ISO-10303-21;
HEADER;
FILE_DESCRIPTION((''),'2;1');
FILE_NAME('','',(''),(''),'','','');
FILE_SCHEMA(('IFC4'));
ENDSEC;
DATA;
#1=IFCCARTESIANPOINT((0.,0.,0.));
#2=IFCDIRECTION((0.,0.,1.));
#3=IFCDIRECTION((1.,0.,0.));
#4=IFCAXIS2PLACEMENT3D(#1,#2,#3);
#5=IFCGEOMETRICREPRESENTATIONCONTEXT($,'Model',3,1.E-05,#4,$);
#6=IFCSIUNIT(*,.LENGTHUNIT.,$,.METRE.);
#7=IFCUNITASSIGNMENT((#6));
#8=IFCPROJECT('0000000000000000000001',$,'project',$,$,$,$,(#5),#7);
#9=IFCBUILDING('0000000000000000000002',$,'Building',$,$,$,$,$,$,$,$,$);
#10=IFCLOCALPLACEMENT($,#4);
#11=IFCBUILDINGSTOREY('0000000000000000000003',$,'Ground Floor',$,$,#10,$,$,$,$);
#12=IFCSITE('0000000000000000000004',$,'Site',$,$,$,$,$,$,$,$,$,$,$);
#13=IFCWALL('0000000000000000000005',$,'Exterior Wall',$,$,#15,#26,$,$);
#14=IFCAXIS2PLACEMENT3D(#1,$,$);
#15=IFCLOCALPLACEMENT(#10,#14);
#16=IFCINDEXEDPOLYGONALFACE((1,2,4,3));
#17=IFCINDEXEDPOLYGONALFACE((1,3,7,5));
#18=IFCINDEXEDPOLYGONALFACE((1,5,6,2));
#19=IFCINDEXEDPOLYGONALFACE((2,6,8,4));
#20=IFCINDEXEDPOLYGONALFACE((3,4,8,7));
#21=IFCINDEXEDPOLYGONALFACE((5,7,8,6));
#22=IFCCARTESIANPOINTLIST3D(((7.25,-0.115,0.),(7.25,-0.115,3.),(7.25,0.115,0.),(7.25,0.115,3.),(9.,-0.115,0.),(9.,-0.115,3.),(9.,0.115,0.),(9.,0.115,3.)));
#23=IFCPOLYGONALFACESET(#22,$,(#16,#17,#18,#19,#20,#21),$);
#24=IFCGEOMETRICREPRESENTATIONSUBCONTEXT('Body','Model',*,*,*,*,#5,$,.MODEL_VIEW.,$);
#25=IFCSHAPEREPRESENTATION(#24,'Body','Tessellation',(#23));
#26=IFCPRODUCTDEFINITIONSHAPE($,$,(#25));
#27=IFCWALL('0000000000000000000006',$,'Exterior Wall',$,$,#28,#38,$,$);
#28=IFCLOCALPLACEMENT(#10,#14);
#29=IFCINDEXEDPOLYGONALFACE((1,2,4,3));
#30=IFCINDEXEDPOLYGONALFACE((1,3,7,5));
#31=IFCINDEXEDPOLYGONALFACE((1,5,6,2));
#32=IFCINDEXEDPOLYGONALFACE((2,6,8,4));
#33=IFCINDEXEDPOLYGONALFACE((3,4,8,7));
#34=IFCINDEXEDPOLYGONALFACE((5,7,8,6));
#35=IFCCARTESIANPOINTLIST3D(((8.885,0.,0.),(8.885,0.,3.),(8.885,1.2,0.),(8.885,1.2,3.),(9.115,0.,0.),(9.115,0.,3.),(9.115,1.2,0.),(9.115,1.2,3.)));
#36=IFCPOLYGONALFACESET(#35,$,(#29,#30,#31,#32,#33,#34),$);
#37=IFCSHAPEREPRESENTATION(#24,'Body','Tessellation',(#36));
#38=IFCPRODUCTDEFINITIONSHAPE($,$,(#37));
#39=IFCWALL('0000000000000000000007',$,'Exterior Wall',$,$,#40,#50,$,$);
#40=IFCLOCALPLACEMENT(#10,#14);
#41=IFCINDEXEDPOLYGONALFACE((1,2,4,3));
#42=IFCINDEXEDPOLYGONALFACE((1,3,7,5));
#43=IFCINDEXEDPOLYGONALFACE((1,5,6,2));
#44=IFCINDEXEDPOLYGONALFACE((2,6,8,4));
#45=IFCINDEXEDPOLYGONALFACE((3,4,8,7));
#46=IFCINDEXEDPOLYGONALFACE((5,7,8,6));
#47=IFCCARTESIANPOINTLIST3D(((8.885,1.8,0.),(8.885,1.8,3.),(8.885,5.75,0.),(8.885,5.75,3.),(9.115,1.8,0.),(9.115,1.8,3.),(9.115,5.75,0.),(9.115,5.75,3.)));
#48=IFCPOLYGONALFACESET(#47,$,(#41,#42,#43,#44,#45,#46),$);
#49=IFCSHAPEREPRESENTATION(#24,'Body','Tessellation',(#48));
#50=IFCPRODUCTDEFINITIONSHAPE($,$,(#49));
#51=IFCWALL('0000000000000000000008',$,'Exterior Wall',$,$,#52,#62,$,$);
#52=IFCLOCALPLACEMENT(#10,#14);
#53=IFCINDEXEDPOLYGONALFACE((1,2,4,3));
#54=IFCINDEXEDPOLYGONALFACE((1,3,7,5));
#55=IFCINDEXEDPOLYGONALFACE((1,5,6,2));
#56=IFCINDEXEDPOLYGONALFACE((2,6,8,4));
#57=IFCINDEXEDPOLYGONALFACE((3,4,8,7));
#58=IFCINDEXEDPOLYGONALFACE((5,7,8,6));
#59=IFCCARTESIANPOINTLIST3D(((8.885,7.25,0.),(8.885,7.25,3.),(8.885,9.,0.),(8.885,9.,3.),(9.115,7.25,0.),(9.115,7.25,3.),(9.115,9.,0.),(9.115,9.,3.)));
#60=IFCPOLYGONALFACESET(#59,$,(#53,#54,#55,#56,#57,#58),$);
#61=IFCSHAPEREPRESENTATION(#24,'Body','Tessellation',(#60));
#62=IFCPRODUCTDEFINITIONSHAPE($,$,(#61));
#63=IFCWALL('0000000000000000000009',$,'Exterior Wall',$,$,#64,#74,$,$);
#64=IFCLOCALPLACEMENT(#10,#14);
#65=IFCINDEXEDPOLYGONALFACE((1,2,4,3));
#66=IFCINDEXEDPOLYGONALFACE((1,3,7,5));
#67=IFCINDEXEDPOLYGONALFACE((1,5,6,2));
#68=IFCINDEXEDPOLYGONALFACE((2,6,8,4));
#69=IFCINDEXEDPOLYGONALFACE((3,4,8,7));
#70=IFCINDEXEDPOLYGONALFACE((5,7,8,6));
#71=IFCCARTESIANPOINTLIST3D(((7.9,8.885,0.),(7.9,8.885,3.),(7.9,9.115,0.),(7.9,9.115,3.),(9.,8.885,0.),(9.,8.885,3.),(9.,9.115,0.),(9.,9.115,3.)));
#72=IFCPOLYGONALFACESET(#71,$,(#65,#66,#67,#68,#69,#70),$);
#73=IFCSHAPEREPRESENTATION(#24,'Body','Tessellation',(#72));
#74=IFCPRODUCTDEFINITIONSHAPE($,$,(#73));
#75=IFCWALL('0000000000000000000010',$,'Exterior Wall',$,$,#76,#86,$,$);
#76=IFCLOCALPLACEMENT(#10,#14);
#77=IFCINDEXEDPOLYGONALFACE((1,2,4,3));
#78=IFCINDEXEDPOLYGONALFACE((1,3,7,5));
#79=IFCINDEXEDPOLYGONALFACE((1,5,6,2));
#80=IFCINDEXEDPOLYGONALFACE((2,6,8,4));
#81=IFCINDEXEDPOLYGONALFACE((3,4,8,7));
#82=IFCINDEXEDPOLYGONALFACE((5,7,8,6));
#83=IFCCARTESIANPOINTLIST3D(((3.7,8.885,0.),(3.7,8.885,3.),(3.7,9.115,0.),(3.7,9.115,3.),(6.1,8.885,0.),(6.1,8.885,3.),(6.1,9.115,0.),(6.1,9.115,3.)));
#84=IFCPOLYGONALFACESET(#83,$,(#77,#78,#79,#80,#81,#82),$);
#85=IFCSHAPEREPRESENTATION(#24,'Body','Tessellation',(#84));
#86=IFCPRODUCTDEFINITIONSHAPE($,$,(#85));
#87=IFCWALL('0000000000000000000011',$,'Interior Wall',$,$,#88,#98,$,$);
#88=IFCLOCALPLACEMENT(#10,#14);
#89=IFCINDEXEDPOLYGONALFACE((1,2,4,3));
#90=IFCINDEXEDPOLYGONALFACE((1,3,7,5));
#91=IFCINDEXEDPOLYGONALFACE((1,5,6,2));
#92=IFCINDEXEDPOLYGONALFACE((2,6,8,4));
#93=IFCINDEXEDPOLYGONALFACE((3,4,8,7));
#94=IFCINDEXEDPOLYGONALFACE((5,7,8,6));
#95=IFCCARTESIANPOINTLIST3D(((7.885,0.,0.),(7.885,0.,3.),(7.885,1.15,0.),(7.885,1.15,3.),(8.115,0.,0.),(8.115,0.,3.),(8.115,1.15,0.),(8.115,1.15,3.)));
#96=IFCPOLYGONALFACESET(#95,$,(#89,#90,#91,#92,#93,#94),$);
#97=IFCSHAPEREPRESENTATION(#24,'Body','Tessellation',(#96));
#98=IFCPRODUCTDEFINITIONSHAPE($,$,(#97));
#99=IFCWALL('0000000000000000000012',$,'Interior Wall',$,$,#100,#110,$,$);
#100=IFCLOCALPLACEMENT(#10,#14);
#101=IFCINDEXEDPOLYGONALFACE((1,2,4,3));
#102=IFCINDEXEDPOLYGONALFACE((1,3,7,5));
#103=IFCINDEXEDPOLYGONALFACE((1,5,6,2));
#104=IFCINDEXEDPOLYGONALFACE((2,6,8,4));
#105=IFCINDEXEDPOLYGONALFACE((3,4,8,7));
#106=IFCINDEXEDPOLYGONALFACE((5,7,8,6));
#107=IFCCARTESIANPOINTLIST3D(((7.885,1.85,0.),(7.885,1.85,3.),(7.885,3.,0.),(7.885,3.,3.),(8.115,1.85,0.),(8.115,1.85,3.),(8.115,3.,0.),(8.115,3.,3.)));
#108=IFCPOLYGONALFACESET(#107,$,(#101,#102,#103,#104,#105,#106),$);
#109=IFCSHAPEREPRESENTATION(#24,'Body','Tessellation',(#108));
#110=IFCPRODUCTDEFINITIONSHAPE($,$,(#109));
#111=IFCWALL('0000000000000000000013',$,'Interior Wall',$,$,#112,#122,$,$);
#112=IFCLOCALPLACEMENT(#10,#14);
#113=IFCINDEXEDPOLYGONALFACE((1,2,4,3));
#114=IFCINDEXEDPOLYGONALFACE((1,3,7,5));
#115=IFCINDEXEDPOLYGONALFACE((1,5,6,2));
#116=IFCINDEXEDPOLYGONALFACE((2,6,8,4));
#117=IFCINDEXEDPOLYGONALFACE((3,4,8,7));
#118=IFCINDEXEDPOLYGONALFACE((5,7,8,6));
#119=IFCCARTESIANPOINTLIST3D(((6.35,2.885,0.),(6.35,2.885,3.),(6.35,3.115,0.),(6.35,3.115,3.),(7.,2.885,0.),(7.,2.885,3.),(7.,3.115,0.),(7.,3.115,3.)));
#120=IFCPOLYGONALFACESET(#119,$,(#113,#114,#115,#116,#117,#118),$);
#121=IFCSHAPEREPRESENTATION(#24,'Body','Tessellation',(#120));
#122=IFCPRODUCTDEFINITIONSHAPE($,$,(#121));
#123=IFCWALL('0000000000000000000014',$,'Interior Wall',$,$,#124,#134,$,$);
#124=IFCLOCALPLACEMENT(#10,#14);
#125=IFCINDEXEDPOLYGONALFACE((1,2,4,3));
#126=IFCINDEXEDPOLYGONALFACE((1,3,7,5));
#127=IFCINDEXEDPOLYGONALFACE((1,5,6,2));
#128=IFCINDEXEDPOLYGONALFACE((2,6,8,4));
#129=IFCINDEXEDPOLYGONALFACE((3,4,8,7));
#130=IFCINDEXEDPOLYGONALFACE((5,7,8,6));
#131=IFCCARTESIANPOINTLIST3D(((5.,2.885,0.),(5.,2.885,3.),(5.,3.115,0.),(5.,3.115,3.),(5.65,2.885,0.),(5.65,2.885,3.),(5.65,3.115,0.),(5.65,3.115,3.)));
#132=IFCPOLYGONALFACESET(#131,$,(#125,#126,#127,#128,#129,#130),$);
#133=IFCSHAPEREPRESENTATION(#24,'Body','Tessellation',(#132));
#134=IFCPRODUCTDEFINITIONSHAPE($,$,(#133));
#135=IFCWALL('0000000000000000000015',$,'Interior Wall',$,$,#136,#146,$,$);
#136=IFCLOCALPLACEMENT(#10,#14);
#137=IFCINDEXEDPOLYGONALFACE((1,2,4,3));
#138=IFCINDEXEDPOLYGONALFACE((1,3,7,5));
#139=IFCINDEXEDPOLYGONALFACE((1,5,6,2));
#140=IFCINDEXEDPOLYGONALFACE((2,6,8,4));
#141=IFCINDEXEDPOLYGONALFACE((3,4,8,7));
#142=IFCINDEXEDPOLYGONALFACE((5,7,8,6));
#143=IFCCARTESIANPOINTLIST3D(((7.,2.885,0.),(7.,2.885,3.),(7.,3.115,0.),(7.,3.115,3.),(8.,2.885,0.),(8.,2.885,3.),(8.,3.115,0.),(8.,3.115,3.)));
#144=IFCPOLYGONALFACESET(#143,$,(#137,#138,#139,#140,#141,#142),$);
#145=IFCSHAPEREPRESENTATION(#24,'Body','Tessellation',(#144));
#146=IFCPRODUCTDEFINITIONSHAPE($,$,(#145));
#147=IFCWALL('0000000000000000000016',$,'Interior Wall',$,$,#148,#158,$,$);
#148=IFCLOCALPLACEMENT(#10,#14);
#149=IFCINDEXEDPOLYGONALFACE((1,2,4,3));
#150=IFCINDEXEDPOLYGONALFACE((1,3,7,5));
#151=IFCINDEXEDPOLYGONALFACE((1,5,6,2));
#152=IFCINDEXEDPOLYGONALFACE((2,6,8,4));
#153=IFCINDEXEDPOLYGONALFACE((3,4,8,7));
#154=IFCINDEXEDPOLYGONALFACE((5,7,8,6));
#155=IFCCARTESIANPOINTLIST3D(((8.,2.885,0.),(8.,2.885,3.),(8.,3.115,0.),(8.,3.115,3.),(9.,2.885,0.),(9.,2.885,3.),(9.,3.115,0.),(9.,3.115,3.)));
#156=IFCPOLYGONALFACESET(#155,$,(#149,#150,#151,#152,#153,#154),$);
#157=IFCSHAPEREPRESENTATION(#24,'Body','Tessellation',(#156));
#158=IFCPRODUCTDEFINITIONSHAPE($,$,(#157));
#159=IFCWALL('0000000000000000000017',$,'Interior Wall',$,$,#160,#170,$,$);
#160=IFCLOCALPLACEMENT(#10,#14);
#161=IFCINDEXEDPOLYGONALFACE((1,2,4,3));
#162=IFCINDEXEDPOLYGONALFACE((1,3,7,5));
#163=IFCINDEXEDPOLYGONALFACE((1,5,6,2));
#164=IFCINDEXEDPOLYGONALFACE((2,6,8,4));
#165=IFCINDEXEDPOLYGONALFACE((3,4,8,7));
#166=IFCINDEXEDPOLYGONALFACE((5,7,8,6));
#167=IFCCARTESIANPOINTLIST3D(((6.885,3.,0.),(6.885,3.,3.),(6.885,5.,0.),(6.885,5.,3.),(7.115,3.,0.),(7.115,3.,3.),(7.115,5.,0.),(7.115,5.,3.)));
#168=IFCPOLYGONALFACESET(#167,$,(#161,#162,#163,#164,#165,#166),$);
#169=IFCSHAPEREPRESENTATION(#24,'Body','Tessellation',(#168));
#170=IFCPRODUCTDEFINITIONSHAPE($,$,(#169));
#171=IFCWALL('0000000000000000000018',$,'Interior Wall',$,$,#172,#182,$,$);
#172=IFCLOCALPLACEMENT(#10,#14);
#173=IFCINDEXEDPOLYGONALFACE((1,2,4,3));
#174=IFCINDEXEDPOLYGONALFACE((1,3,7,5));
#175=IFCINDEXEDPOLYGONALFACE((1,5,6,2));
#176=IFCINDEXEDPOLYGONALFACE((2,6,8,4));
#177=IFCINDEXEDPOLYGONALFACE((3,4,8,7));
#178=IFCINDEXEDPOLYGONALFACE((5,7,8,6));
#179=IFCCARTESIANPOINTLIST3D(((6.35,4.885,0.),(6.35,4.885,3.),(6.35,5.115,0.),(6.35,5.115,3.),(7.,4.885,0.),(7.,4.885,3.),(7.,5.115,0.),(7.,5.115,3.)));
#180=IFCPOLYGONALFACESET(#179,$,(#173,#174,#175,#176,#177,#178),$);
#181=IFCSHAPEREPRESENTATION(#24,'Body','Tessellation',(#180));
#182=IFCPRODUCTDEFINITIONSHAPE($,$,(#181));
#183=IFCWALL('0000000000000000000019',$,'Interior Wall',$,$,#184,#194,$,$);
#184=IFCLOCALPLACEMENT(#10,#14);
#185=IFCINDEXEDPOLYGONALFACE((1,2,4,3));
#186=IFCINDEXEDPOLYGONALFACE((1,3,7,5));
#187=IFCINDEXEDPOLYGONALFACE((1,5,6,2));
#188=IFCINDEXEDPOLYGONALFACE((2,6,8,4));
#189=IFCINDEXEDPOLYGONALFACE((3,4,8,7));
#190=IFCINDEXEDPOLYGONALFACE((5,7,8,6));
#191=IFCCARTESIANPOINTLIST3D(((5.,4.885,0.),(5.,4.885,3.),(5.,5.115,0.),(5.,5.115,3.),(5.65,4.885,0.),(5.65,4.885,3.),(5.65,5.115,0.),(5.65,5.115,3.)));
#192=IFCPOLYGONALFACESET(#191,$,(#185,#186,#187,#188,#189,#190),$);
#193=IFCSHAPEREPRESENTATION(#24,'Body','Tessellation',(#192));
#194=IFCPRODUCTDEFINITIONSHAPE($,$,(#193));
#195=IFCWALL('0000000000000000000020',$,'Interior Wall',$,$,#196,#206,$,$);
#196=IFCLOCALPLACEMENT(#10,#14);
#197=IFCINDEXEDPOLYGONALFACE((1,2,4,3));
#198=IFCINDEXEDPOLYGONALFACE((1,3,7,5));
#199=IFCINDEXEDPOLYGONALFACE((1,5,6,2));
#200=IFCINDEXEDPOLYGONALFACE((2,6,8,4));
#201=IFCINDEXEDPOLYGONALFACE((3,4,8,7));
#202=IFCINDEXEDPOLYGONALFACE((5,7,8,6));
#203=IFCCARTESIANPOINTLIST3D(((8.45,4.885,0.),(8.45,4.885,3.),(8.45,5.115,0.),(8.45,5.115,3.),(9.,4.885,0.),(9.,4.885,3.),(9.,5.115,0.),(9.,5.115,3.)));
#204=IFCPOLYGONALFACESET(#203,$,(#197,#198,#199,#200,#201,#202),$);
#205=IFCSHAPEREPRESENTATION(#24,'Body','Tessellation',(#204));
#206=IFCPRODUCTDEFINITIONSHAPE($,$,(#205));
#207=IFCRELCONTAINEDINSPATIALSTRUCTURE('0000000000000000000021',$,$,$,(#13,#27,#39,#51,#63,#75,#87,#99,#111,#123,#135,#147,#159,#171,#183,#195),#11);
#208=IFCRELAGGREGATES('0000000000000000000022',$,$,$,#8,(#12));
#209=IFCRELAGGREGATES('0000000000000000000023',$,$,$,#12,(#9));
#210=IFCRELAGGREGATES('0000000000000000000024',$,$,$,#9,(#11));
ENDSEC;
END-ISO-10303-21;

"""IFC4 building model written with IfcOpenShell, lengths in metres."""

from ifc_helpers import new_model, si_unit, frame, origin_with_axes, place, context, subcontext, project, spatial, indexed_curve, outline, extrude, element, save


model = new_model("IFC4")

# Units and contexts
model_context = context("Model", 3, precision=1e-05, world=origin_with_axes())
body_context = subcontext(model_context, "Body", "Model", "MODEL_VIEW")
ifc_project = project(units=[si_unit("LENGTHUNIT", "METRE")], contexts=[model_context])

# Site, building, storey
site = spatial("IfcSite", under=ifc_project, Name="Site")
building = spatial("IfcBuilding", under=site, Name="Building")
storey_placement = place(None, origin_with_axes())
storey = spatial("IfcBuildingStorey", under=building, at=storey_placement, Name="Ground Floor")

# Walls
wall_1_placement = place(storey_placement, frame((7.25, 0.0, 0.0), z_axis=(0.0, 0.0, 1.0), x_axis=(1.0, 0.0, 0.0)))
element("IfcWall", 1, at=wall_1_placement, inside=storey, Name="Exterior Wall", context=body_context, shape_type="SweptSolid", body=[
    extrude(outline(indexed_curve([(0.0, 0.0), (0.0, 0.23), (1.75, 0.23), (1.75, 0.0), (0.0, 0.0)], self_intersect=False)), frame((0.0, -0.115, 0.0), z_axis=(0.0, 0.0, 1.0), x_axis=(1.0, 0.0, 0.0)), (0.0, 0.0, 1.0), 3.0),
])
wall_2_placement = place(storey_placement, frame((9.0, 0.0, 0.0), z_axis=(0.0, 0.0, 1.0), x_axis=(0.0, 1.0, 0.0)))
element("IfcWall", 2, at=wall_2_placement, inside=storey, Name="Exterior Wall", context=body_context, shape_type="SweptSolid", body=[
    extrude(outline(indexed_curve([(0.0, 0.0), (0.0, 0.23), (1.2, 0.23), (1.2, 0.0), (0.0, 0.0)], self_intersect=False)), frame((0.0, -0.115, 0.0), z_axis=(0.0, 0.0, 1.0), x_axis=(1.0, 0.0, 0.0)), (0.0, 0.0, 1.0), 3.0),
])
wall_3_placement = place(storey_placement, frame((9.0, 1.8, 0.0), z_axis=(0.0, 0.0, 1.0), x_axis=(0.0, 1.0, 0.0)))
element("IfcWall", 3, at=wall_3_placement, inside=storey, Name="Exterior Wall", context=body_context, shape_type="SweptSolid", body=[
    extrude(outline(indexed_curve([(0.0, 0.0), (0.0, 0.23), (3.95, 0.23), (3.95, 0.0), (0.0, 0.0)], self_intersect=False)), frame((0.0, -0.115, 0.0), z_axis=(0.0, 0.0, 1.0), x_axis=(1.0, 0.0, 0.0)), (0.0, 0.0, 1.0), 3.0),
])
wall_4_placement = place(storey_placement, frame((9.0, 7.25, 0.0), z_axis=(0.0, 0.0, 1.0), x_axis=(0.0, 1.0, 0.0)))
element("IfcWall", 4, at=wall_4_placement, inside=storey, Name="Exterior Wall", context=body_context, shape_type="SweptSolid", body=[
    extrude(outline(indexed_curve([(0.0, 0.0), (0.0, 0.23), (1.75, 0.23), (1.75, 0.0), (0.0, 0.0)], self_intersect=False)), frame((0.0, -0.115, 0.0), z_axis=(0.0, 0.0, 1.0), x_axis=(1.0, 0.0, 0.0)), (0.0, 0.0, 1.0), 3.0),
])
wall_5_placement = place(storey_placement, frame((9.0, 9.0, 0.0), z_axis=(0.0, 0.0, 1.0), x_axis=(-1.0, 0.0, 0.0)))
element("IfcWall", 5, at=wall_5_placement, inside=storey, Name="Exterior Wall", context=body_context, shape_type="SweptSolid", body=[
    extrude(outline(indexed_curve([(0.0, 0.0), (0.0, 0.23), (1.1, 0.23), (1.1, 0.0), (0.0, 0.0)], self_intersect=False)), frame((0.0, -0.115, 0.0), z_axis=(0.0, 0.0, 1.0), x_axis=(1.0, 0.0, 0.0)), (0.0, 0.0, 1.0), 3.0),
])
wall_6_placement = place(storey_placement, frame((6.1, 9.0, 0.0), z_axis=(0.0, 0.0, 1.0), x_axis=(-1.0, 0.0, 0.0)))
element("IfcWall", 6, at=wall_6_placement, inside=storey, Name="Exterior Wall", context=body_context, shape_type="SweptSolid", body=[
    extrude(outline(indexed_curve([(0.0, 0.0), (0.0, 0.23), (2.4, 0.23), (2.4, 0.0), (0.0, 0.0)], self_intersect=False)), frame((0.0, -0.115, 0.0), z_axis=(0.0, 0.0, 1.0), x_axis=(1.0, 0.0, 0.0)), (0.0, 0.0, 1.0), 3.0),
])
for number, where, z_axis, x_axis, name in (
    (7, (8.0, 0.0, 0.0), (0.0, 0.0, 1.0), (0.0, 1.0, 0.0), "Interior Wall"),
    (8, (8.0, 1.85, 0.0), (0.0, 0.0, 1.0), (0.0, 1.0, 0.0), "Interior Wall"),
):
    element("IfcWall", number, at=place(storey_placement, frame(where, z_axis=z_axis, x_axis=x_axis)), inside=storey, Name=name, context=body_context, shape_type="SweptSolid", body=[
        extrude(outline(indexed_curve([(0.0, 0.0), (0.0, 0.23), (1.15, 0.23), (1.15, 0.0), (0.0, 0.0)], self_intersect=False)), frame((0.0, -0.115, 0.0), z_axis=(0.0, 0.0, 1.0), x_axis=(1.0, 0.0, 0.0)), (0.0, 0.0, 1.0), 3.0),
    ])
for number, where, z_axis, x_axis, name in (
    (9, (7.0, 3.0, 0.0), (0.0, 0.0, 1.0), (-1.0, 0.0, 0.0), "Interior Wall"),
    (10, (5.65, 3.0, 0.0), (0.0, 0.0, 1.0), (-1.0, 0.0, 0.0), "Interior Wall"),
):
    element("IfcWall", number, at=place(storey_placement, frame(where, z_axis=z_axis, x_axis=x_axis)), inside=storey, Name=name, context=body_context, shape_type="SweptSolid", body=[
        extrude(outline(indexed_curve([(0.0, 0.0), (0.0, 0.23), (0.65, 0.23), (0.65, 0.0), (0.0, 0.0)], self_intersect=False)), frame((0.0, -0.115, 0.0), z_axis=(0.0, 0.0, 1.0), x_axis=(1.0, 0.0, 0.0)), (0.0, 0.0, 1.0), 3.0),
    ])
for number, where, z_axis, x_axis, name in (
    (11, (8.0, 3.0, 0.0), (0.0, 0.0, 1.0), (-1.0, 0.0, 0.0), "Interior Wall"),
    (12, (9.0, 3.0, 0.0), (0.0, 0.0, 1.0), (-1.0, 0.0, 0.0), "Interior Wall"),
):
    element("IfcWall", number, at=place(storey_placement, frame(where, z_axis=z_axis, x_axis=x_axis)), inside=storey, Name=name, context=body_context, shape_type="SweptSolid", body=[
        extrude(outline(indexed_curve([(0.0, 0.0), (0.0, 0.23), (1.0, 0.23), (1.0, 0.0), (0.0, 0.0)], self_intersect=False)), frame((0.0, -0.115, 0.0), z_axis=(0.0, 0.0, 1.0), x_axis=(1.0, 0.0, 0.0)), (0.0, 0.0, 1.0), 3.0),
    ])
wall_7_placement = place(storey_placement, frame((7.0, 3.0, 0.0), z_axis=(0.0, 0.0, 1.0), x_axis=(0.0, 1.0, 0.0)))
element("IfcWall", 13, at=wall_7_placement, inside=storey, Name="Interior Wall", context=body_context, shape_type="SweptSolid", body=[
    extrude(outline(indexed_curve([(0.0, 0.0), (0.0, 0.23), (2.0, 0.23), (2.0, 0.0), (0.0, 0.0)], self_intersect=False)), frame((0.0, -0.115, 0.0), z_axis=(0.0, 0.0, 1.0), x_axis=(1.0, 0.0, 0.0)), (0.0, 0.0, 1.0), 3.0),
])
for number, where, z_axis, x_axis, name in (
    (14, (7.0, 5.0, 0.0), (0.0, 0.0, 1.0), (-1.0, 0.0, 0.0), "Interior Wall"),
    (15, (5.65, 5.0, 0.0), (0.0, 0.0, 1.0), (-1.0, 0.0, 0.0), "Interior Wall"),
):
    element("IfcWall", number, at=place(storey_placement, frame(where, z_axis=z_axis, x_axis=x_axis)), inside=storey, Name=name, context=body_context, shape_type="SweptSolid", body=[
        extrude(outline(indexed_curve([(0.0, 0.0), (0.0, 0.23), (0.65, 0.23), (0.65, 0.0), (0.0, 0.0)], self_intersect=False)), frame((0.0, -0.115, 0.0), z_axis=(0.0, 0.0, 1.0), x_axis=(1.0, 0.0, 0.0)), (0.0, 0.0, 1.0), 3.0),
    ])
wall_8_placement = place(storey_placement, frame((9.0, 5.0, 0.0), z_axis=(0.0, 0.0, 1.0), x_axis=(-1.0, 0.0, 0.0)))
element("IfcWall", 16, at=wall_8_placement, inside=storey, Name="Interior Wall", context=body_context, shape_type="SweptSolid", body=[
    extrude(outline(indexed_curve([(0.0, 0.0), (0.0, 0.23), (0.55, 0.23), (0.55, 0.0), (0.0, 0.0)], self_intersect=False)), frame((0.0, -0.115, 0.0), z_axis=(0.0, 0.0, 1.0), x_axis=(1.0, 0.0, 0.0)), (0.0, 0.0, 1.0), 3.0),
])

save(model, "model.ifc")
